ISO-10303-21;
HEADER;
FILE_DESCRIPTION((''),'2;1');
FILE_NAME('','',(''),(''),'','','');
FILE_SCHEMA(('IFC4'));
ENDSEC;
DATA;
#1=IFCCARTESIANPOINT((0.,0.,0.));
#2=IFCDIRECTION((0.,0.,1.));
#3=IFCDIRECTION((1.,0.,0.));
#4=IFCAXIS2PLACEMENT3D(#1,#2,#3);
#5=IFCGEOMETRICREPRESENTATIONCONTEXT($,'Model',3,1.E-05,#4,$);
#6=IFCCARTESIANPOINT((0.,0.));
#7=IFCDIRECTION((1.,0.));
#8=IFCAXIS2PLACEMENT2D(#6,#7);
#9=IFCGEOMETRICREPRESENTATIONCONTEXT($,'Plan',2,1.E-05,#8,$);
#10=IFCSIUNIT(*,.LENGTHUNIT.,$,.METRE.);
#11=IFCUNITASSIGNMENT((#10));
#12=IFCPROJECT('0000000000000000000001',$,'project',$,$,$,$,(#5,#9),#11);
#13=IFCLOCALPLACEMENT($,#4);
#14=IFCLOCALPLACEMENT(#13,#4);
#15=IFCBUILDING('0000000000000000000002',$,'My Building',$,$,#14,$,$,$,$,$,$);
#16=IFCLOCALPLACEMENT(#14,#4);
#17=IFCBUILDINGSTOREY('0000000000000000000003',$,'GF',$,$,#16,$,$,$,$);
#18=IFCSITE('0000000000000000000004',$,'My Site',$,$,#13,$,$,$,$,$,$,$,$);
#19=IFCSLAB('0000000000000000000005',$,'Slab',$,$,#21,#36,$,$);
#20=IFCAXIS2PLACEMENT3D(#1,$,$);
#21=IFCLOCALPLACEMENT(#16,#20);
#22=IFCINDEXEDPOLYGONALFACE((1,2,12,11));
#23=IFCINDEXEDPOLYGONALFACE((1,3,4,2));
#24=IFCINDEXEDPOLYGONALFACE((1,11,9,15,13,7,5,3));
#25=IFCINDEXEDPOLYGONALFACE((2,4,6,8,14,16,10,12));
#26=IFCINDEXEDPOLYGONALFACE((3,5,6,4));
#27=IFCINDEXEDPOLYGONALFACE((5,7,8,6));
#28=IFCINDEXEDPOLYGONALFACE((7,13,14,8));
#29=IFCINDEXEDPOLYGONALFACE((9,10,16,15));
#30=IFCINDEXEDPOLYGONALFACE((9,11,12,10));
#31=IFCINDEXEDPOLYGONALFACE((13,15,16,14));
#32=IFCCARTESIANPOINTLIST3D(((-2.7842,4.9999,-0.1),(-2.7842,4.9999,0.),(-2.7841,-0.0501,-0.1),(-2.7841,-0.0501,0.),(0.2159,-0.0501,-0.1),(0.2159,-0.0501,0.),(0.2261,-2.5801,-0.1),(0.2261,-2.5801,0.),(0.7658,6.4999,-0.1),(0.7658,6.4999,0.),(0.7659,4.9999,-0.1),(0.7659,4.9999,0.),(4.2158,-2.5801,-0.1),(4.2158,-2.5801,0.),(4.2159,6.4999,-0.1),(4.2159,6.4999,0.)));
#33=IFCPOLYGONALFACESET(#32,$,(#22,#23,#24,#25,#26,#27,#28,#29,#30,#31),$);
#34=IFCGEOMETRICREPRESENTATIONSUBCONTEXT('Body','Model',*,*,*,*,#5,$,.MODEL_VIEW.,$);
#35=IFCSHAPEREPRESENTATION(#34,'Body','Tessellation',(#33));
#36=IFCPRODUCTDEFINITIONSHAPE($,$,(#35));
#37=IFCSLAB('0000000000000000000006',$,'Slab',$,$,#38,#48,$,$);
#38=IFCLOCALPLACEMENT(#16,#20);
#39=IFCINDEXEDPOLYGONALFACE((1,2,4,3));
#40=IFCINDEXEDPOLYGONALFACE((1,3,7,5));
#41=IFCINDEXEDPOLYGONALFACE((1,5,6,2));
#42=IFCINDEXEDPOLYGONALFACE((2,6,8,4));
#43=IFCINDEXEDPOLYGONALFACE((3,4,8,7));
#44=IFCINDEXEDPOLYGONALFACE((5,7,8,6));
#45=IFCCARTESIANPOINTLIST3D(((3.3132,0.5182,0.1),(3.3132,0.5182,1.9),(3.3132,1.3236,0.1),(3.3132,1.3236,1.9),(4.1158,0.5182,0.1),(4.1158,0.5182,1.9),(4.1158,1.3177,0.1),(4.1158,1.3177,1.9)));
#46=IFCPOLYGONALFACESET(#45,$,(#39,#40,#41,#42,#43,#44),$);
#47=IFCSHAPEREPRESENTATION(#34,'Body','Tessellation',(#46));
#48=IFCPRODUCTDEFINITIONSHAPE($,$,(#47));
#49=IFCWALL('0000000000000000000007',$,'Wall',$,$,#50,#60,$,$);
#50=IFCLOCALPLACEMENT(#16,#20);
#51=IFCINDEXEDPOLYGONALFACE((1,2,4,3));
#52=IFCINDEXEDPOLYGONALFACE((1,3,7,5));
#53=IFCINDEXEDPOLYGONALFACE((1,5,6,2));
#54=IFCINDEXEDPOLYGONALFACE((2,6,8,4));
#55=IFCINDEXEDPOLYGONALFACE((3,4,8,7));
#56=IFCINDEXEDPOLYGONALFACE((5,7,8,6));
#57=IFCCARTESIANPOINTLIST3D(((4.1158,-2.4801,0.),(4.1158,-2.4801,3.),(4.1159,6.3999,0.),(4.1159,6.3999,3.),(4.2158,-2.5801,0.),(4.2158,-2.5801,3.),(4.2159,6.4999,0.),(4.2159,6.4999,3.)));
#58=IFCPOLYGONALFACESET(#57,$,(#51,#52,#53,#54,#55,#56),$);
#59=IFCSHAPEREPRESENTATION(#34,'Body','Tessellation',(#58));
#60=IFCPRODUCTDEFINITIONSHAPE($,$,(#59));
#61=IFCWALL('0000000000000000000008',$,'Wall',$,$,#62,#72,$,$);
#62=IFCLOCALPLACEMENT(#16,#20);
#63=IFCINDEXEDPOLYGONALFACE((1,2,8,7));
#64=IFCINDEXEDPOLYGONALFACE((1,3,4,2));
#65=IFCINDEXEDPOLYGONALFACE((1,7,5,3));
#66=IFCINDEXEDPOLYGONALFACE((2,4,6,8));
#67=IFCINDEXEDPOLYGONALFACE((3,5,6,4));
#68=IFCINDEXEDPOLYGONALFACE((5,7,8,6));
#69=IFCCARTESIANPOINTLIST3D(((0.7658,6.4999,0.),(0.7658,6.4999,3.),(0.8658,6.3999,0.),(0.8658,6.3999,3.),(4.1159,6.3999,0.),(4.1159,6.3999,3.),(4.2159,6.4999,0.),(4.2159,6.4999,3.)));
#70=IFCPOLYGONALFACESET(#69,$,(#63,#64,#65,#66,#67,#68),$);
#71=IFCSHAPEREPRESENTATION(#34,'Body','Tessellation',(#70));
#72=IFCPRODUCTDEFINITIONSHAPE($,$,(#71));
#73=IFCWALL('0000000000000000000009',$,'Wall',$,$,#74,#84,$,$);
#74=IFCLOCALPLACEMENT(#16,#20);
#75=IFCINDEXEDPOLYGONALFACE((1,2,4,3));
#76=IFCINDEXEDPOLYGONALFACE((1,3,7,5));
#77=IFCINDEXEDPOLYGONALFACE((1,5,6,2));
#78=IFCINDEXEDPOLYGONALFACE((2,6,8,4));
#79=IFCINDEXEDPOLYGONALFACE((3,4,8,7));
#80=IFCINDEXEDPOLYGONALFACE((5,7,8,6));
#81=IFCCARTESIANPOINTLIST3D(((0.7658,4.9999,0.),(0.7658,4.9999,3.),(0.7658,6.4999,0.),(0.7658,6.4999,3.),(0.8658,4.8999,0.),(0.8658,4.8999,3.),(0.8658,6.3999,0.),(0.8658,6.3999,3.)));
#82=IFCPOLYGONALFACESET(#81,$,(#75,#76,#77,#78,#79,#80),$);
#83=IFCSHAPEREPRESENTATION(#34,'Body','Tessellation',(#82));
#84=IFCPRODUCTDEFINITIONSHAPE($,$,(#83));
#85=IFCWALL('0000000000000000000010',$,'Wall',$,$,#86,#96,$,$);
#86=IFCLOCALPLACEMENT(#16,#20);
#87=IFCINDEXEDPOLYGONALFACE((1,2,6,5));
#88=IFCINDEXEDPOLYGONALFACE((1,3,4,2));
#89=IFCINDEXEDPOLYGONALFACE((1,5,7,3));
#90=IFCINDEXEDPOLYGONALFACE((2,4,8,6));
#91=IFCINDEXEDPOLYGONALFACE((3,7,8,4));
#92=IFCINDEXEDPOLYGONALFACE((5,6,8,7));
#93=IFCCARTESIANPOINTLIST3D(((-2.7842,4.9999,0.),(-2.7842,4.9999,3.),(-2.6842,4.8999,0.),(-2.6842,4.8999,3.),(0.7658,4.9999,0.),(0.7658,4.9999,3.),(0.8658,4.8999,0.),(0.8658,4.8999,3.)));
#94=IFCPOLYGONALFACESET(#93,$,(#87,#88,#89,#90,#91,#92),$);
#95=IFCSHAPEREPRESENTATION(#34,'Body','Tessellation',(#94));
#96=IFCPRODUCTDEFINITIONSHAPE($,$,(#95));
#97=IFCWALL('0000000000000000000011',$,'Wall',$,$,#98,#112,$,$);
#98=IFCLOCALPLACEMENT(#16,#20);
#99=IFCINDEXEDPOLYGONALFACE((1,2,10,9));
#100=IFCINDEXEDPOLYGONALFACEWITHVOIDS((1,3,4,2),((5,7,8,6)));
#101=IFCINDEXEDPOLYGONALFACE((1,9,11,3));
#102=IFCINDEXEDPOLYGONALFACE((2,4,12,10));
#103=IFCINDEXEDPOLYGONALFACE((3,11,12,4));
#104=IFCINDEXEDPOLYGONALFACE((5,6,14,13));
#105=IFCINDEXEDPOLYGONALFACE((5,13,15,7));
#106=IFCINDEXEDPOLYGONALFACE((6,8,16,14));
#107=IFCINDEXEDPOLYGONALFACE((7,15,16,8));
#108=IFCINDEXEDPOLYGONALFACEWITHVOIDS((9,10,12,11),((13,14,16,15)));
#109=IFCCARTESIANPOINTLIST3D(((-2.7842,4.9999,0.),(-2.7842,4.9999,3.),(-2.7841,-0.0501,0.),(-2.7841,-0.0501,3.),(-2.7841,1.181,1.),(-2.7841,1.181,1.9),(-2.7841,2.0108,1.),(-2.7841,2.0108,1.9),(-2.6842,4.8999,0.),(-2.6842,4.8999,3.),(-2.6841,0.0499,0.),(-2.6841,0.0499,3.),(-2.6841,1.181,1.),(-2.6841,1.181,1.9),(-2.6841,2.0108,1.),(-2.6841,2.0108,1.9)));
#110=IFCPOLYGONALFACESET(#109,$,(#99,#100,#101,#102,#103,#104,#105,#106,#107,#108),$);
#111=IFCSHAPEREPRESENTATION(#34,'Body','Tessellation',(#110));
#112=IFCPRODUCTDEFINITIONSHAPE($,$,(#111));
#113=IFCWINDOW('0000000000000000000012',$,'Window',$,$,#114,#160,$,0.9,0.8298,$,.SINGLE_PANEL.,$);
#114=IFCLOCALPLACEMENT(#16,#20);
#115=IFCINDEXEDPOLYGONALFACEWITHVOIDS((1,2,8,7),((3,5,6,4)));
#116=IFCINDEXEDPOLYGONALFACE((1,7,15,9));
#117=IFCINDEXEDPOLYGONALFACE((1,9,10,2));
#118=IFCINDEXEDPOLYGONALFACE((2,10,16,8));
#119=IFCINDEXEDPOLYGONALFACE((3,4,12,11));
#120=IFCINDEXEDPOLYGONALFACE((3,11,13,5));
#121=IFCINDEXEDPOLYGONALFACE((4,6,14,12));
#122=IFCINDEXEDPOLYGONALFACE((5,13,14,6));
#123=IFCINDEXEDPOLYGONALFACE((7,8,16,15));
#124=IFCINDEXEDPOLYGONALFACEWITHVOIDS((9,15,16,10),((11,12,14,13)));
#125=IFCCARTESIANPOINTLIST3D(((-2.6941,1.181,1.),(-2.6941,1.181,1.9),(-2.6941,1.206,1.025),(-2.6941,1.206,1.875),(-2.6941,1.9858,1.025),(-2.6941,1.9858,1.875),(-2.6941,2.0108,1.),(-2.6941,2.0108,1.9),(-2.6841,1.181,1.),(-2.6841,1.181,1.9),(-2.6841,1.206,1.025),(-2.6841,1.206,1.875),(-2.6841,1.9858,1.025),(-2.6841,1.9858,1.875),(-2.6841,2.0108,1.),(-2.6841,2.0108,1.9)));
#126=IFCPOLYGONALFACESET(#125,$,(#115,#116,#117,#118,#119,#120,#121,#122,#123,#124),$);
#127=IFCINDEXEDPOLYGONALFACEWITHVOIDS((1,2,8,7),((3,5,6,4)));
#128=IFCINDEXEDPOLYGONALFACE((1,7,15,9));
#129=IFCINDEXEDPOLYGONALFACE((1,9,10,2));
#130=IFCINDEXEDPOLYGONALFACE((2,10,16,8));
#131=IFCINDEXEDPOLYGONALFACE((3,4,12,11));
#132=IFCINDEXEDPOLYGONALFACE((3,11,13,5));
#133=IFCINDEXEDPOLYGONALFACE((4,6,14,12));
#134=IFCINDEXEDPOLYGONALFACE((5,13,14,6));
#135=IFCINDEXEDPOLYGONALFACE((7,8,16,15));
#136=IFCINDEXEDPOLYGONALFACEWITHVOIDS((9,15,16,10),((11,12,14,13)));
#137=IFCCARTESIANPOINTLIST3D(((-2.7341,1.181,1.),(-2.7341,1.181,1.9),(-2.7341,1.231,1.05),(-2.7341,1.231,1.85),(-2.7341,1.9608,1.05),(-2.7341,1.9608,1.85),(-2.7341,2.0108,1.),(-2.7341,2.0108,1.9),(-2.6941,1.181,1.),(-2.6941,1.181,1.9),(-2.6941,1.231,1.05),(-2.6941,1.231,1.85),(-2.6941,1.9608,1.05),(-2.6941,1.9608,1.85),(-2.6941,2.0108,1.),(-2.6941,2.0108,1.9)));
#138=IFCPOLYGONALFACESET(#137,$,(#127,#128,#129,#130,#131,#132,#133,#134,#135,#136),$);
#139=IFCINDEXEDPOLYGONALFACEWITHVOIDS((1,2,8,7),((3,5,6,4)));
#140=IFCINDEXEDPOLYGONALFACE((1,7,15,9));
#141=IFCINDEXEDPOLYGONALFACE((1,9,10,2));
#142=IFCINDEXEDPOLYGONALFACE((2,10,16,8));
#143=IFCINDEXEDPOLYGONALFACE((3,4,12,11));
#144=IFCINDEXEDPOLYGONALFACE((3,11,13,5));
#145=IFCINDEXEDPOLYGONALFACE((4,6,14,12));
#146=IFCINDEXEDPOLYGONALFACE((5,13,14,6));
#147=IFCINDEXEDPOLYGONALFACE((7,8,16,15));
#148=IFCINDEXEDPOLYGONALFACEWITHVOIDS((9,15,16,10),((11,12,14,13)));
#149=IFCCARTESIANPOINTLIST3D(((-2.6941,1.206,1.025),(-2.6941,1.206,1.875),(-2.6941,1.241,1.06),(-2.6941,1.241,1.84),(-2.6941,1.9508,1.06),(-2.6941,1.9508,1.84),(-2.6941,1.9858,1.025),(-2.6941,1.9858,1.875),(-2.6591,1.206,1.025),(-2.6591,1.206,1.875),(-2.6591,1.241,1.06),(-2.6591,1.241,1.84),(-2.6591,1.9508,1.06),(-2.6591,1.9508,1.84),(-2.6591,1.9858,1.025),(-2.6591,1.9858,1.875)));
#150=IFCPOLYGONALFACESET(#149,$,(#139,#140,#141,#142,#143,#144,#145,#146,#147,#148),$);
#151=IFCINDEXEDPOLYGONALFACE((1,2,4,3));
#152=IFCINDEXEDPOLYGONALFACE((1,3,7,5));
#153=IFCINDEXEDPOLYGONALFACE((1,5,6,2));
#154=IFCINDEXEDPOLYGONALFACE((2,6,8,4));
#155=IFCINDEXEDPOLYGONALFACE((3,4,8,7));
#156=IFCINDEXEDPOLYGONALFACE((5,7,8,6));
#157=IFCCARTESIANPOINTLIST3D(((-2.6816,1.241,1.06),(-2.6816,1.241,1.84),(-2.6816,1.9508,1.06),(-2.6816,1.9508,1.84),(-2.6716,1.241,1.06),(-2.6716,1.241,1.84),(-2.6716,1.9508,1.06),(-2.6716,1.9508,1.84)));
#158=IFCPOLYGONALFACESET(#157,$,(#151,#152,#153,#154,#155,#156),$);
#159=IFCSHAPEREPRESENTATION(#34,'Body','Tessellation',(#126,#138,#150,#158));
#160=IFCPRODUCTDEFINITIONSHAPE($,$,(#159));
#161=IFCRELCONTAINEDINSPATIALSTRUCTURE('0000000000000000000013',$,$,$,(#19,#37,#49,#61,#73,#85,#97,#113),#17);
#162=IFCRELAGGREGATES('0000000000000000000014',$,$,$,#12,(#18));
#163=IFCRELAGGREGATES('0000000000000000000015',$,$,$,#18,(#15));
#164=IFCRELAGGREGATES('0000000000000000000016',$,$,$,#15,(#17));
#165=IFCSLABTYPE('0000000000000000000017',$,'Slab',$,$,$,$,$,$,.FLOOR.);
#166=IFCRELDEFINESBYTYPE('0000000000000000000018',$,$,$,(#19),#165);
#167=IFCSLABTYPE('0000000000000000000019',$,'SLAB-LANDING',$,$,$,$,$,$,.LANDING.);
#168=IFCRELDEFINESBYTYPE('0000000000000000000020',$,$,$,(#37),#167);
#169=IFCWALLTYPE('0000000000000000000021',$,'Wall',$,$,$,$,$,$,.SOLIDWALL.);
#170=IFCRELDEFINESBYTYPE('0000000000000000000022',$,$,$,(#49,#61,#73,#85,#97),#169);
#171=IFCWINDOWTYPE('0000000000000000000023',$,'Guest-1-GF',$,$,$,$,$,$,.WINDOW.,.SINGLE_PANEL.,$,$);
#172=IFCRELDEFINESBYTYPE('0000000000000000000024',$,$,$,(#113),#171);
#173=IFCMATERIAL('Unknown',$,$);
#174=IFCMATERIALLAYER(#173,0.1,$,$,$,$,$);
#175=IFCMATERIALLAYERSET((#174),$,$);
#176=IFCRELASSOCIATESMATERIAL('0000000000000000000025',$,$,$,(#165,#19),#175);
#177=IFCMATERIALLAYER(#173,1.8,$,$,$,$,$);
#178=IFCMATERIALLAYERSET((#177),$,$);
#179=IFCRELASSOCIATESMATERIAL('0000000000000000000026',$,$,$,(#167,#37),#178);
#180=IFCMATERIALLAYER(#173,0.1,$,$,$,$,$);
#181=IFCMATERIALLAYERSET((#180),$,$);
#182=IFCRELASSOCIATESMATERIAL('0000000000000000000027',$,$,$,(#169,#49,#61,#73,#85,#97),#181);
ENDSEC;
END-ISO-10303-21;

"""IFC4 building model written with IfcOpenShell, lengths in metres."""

from ifc_helpers import new_model, entity, si_unit, frame, origin_with_axes, origin_2d_with_axis, place, context, subcontext, project, spatial, line, indexed_curve, outline, extrude, shape, source, transform, mapped, material, layer, layer_set, layer_usage, type_object, type_shapes, element, fill, save


model = new_model("IFC4")

# Units and contexts
model_context = context("Model", 3, precision=1e-05, world=origin_with_axes())
plan_context = context("Plan", 2, precision=1e-05, world=origin_2d_with_axis())
body_context_1 = subcontext(model_context, "Body", "Model", "MODEL_VIEW")
body_context_2 = subcontext(plan_context, "Body", "Plan", "PLAN_VIEW")
ifc_project = project(units=[si_unit("LENGTHUNIT", "METRE")], contexts=[model_context, plan_context])

# Site, building, storey
site_placement = place(None, origin_with_axes())
site = spatial("IfcSite", under=ifc_project, at=site_placement, Name="My Site")
building_placement = place(site_placement, origin_with_axes())
building = spatial("IfcBuilding", under=site, at=building_placement, Name="My Building")
storey_placement = place(building_placement, origin_with_axes())
storey = spatial("IfcBuildingStorey", under=building, at=storey_placement, Name="GF")

# Slabs
ifc_material_1 = material(Name="Unknown")
ifc_layer_1 = layer(ifc_material_1, 0.1)
ifc_layer_set_1 = layer_set([ifc_layer_1])
ifc_layer_usage_1 = layer_usage(ifc_layer_set_1, "AXIS3", "POSITIVE", -0.1)
slab_type_1 = type_object("IfcSlabType", Name="Slab", PredefinedType="FLOOR", material=ifc_layer_set_1)
slab_1_placement = place(storey_placement, frame((0.2261, -2.5801, 0.0), z_axis=(0.0, 0.0, 1.0), x_axis=(1.0, 0.0, 0.0)))
element("IfcSlab", 1, at=slab_1_placement, inside=storey, type_object=slab_type_1, material=ifc_layer_usage_1, Name="Slab", context=body_context_1, shape_type="SweptSolid", body=[
    extrude(outline(indexed_curve([(0.0, 0.0), (3.9897, 0.0), (3.9897, 9.08), (0.5397, 9.08), (0.5397, 7.58), (-3.0103, 7.58), (-3.0103, 2.53), (-0.0103, 2.53), (0.0, 0.0)])), frame((0.0, 0.0, -0.1), z_axis=(0.0, 0.0, 1.0), x_axis=(1.0, 0.0, 0.0)), (0.0, 0.0, 1.0), 0.1),
])
ifc_layer_2 = layer(ifc_material_1, 1.8)
ifc_layer_set_2 = layer_set([ifc_layer_2])
ifc_layer_usage_2 = layer_usage(ifc_layer_set_2, "AXIS3", "POSITIVE", -0.1)
slab_type_2 = type_object("IfcSlabType", Name="SLAB-LANDING", PredefinedType="LANDING", material=ifc_layer_set_2)
slab_2_placement = place(storey_placement, frame((3.3132, 1.3236, 0.2), z_axis=(0.0, 0.0, 1.0), x_axis=(1.0, 0.0, 0.0)))
element("IfcSlab", 2, at=slab_2_placement, inside=storey, type_object=slab_type_2, material=ifc_layer_usage_2, Name="Slab", context=body_context_1, shape_type="SweptSolid", body=[
    extrude(outline(indexed_curve([(0.0, 0.0), (0.0, -0.8055), (0.8026, -0.8055), (0.8026, -0.006), (0.0, 0.0)])), frame((0.0, 0.0, -0.1), z_axis=(0.0, 0.0, 1.0), x_axis=(1.0, 0.0, 0.0)), (0.0, 0.0, 1.0), 1.8),
])

# Shared definitions
ifc_layer_3 = layer(ifc_material_1, 0.1)
ifc_layer_set_3 = layer_set([ifc_layer_3])
wall_type = type_object("IfcWallType", Name="Wall", PredefinedType="SOLIDWALL", material=ifc_layer_set_3)

# Walls
ifc_layer_usage_3 = layer_usage(ifc_layer_set_3, "AXIS2", "POSITIVE", 0.0)
wall_1_placement = place(storey_placement, frame((4.2158, -2.5801, 0.0), z_axis=(0.0, 0.0, 1.0), x_axis=(0.0, 1.0, 0.0)))
element("IfcWall", 3, at=wall_1_placement, inside=storey, type_object=wall_type, material=ifc_layer_usage_3, Name="Wall", context=body_context_1, shape_type="SweptSolid", body=[
    extrude(outline(indexed_curve([(0.0, 0.0), (0.1, 0.1), (8.98, 0.1), (9.08, 0.0)], segments=[line(1, 2, 3, 4, 1)])), origin_with_axes(), (0.0, 0.0, 1.0), 3.0),
])
ifc_layer_usage_4 = layer_usage(ifc_layer_set_3, "AXIS2", "POSITIVE", 0.0)
wall_2_placement = place(storey_placement, frame((4.2159, 6.4999, 0.0), z_axis=(0.0, 0.0, 1.0), x_axis=(-1.0, 0.0, 0.0)))
element("IfcWall", 4, at=wall_2_placement, inside=storey, type_object=wall_type, material=ifc_layer_usage_4, Name="Wall", context=body_context_1, shape_type="SweptSolid", body=[
    extrude(outline(indexed_curve([(0.0, 0.0), (0.1, 0.1), (3.35, 0.1), (3.45, 0.0)], segments=[line(1, 2, 3, 4, 1)])), origin_with_axes(), (0.0, 0.0, 1.0), 3.0),
])
ifc_layer_usage_5 = layer_usage(ifc_layer_set_3, "AXIS2", "POSITIVE", 0.0)
wall_3_placement = place(storey_placement, frame((0.7658, 6.4999, 0.0), z_axis=(0.0, 0.0, 1.0), x_axis=(0.0, -1.0, 0.0)))
element("IfcWall", 5, at=wall_3_placement, inside=storey, type_object=wall_type, material=ifc_layer_usage_5, Name="Wall", context=body_context_1, shape_type="SweptSolid", body=[
    extrude(outline(indexed_curve([(0.0, 0.0), (0.1, 0.1), (1.6, 0.1), (1.5, 0.0)], segments=[line(1, 2, 3, 4, 1)])), origin_with_axes(), (0.0, 0.0, 1.0), 3.0),
])
ifc_layer_usage_6 = layer_usage(ifc_layer_set_3, "AXIS2", "POSITIVE", 0.0)
wall_4_placement = place(storey_placement, frame((0.7658, 4.9999, 0.0), z_axis=(0.0, 0.0, 1.0), x_axis=(-1.0, 0.0, 0.0)))
element("IfcWall", 6, at=wall_4_placement, inside=storey, type_object=wall_type, material=ifc_layer_usage_6, Name="Wall", context=body_context_1, shape_type="SweptSolid", body=[
    extrude(outline(indexed_curve([(0.0, 0.0), (-0.1, 0.1), (3.45, 0.1), (3.55, 0.0)], segments=[line(1, 2, 3, 4, 1)])), origin_with_axes(), (0.0, 0.0, 1.0), 3.0),
])

# Wall, opening, window
ifc_layer_usage_7 = layer_usage(ifc_layer_set_3, "AXIS2", "POSITIVE", 0.0)
wall_5_placement = place(storey_placement, frame((-2.7842, 4.9999, 0.0), z_axis=(0.0, 0.0, 1.0), x_axis=(0.0, -1.0, 0.0)))
wall_5 = element("IfcWall", 7, at=wall_5_placement, inside=storey, type_object=wall_type, material=ifc_layer_usage_7, Name="Wall", context=body_context_1, shape_type="SweptSolid", body=[
    extrude(outline(indexed_curve([(0.0, 0.0), (0.1, 0.1), (4.95, 0.1), (5.05, 0.0)], segments=[line(1, 2, 3, 4, 1)])), origin_with_axes(), (0.0, 0.0, 1.0), 3.0),
])
shared_shape_1 = source(origin_with_axes(), body_context_1, "Body", "SweptSolid", [
    extrude(outline(indexed_curve([(0.0, 0.0), (0.8298, 0.0), (0.8298, 0.9), (0.0, 0.9)], segments=[line(1, 2, 3, 4, 1)])), frame((0.0, -0.6, 0.0), z_axis=(0.0, -1.0, 0.0), x_axis=(1.0, 0.0, 0.0)), (0.0, 0.0, -1.0), 1.2),
])
opening_1_placement = place(wall_5_placement, frame((2.989, 0.0, 1.0), z_axis=(0.0, 0.0, 1.0), x_axis=(1.0, 0.0, 0.0)))
opening_1 = element("IfcOpeningElement", 8, at=opening_1_placement, cuts=wall_5, PredefinedType="OPENING", context=body_context_1, shape_type="MappedRepresentation", body=[
    mapped(shared_shape_1, transform((0.0, 0.0, 0.0), x_axis=(1.0, 0.0, 0.0), y_axis=(0.0, 1.0, 0.0), z_axis=(0.0, 0.0, 1.0), scale=1.0)),
])
window_type_1 = type_object("IfcWindowType", Name="Guest-1-GF", PartitioningType="SINGLE_PANEL", PredefinedType="WINDOW")
shared_shape_2 = source(origin_with_axes(), body_context_1, "Body", "SweptSolid", [
    extrude(outline(indexed_curve([(0.0, 0.0), (0.8298, 0.0), (0.8298, 0.9), (0.0, 0.9)], segments=[line(1, 2, 3, 4, 1)]), holes=[indexed_curve([(0.025, 0.025), (0.8048, 0.025), (0.8048, 0.875), (0.025, 0.875)], segments=[line(1, 2, 3, 4, 1)])]), frame((0.0, 0.09, 0.0), z_axis=(0.0, -1.0, 0.0), x_axis=(1.0, 0.0, 0.0)), (0.0, 0.0, -1.0), 0.01),
    extrude(outline(indexed_curve([(0.0, 0.0), (0.8298, 0.0), (0.8298, 0.9), (0.0, 0.9)], segments=[line(1, 2, 3, 4, 1)]), holes=[indexed_curve([(0.05, 0.05), (0.7798, 0.05), (0.7798, 0.85), (0.05, 0.85)], segments=[line(1, 2, 3, 4, 1)])]), frame((0.0, 0.05, 0.0), z_axis=(0.0, -1.0, 0.0), x_axis=(1.0, 0.0, 0.0)), (0.0, 0.0, -1.0), 0.04),
    extrude(outline(indexed_curve([(0.0, 0.0), (0.7798, 0.0), (0.7798, 0.85), (0.0, 0.85)], segments=[line(1, 2, 3, 4, 1)]), holes=[indexed_curve([(0.035, 0.035), (0.7448, 0.035), (0.7448, 0.815), (0.035, 0.815)], segments=[line(1, 2, 3, 4, 1)])]), frame((0.025, 0.09, 0.025), z_axis=(0.0, -1.0, 0.0), x_axis=(1.0, 0.0, 0.0)), (0.0, 0.0, -1.0), 0.035),
    extrude(outline(indexed_curve([(0.035, 0.035), (0.7448, 0.035), (0.7448, 0.815), (0.035, 0.815)], segments=[line(1, 2, 3, 4, 1)])), frame((0.025, 0.1025, 0.025), z_axis=(0.0, -1.0, 0.0), x_axis=(1.0, 0.0, 0.0)), (0.0, 0.0, -1.0), 0.01),
])
shared_shape_3 = source(origin_with_axes(), body_context_2, "Body", "Curve2D", [
    entity("IfcIndexedPolyCurve", entity("IfcCartesianPointList2D", [[0.05, 0.05], [0.7798, 0.05]])),
    entity("IfcIndexedPolyCurve", entity("IfcCartesianPointList2D", [[0.0, 0.1], [0.025, 0.1], [0.025, 0.09], [0.05, 0.09], [0.05, 0.05], [0.0, 0.05]]), [entity("IfcLineIndex", [1, 2, 3, 4, 5, 6, 1])]),
    entity("IfcIndexedPolyCurve", entity("IfcCartesianPointList2D", [[0.8298, 0.1], [0.8048, 0.1], [0.8048, 0.09], [0.7798, 0.09], [0.7798, 0.05], [0.8298, 0.05]]), [entity("IfcLineIndex", [1, 2, 3, 4, 5, 6, 1])]),
    entity("IfcIndexedPolyCurve", entity("IfcCartesianPointList2D", [[0.025, 0.09], [0.06, 0.09], [0.06, 0.125], [0.025, 0.125]]), [entity("IfcLineIndex", [1, 2, 3, 4, 1])]),
    entity("IfcIndexedPolyCurve", entity("IfcCartesianPointList2D", [[0.8048, 0.09], [0.7698, 0.09], [0.7698, 0.125], [0.8048, 0.125]]), [entity("IfcLineIndex", [1, 2, 3, 4, 1])]),
    entity("IfcIndexedPolyCurve", entity("IfcCartesianPointList2D", [[0.06, 0.09], [0.7698, 0.09]])),
    entity("IfcIndexedPolyCurve", entity("IfcCartesianPointList2D", [[0.06, 0.125], [0.7698, 0.125]])),
    entity("IfcIndexedPolyCurve", entity("IfcCartesianPointList2D", [[0.06, 0.1075], [0.7698, 0.1075]])),
])
type_shapes(window_type_1, [shared_shape_2, shared_shape_3])
window_1_placement = place(opening_1_placement, frame((0.0, 0.0, 0.0), z_axis=(0.0, 0.0, 1.0), x_axis=(1.0, 0.0, 0.0)))
window_1 = element("IfcWindow", 9, at=window_1_placement, inside=storey, type_object=window_type_1, Name="Window", OverallHeight=0.9, OverallWidth=0.8298, PartitioningType="SINGLE_PANEL", shapes=[
    shape(body_context_1, "Body", "MappedRepresentation", [mapped(shared_shape_2, transform((0.0, 0.0, 0.0), x_axis=(1.0, 0.0, 0.0), y_axis=(0.0, 1.0, 0.0), z_axis=(0.0, 0.0, 1.0), scale=1.0))]),
    shape(body_context_2, "Body", "MappedRepresentation", [mapped(shared_shape_3, transform((0.0, 0.0, 0.0), x_axis=(1.0, 0.0, 0.0), y_axis=(0.0, 1.0, 0.0), z_axis=(0.0, 0.0, 1.0), scale=1.0))]),
])
fill(opening_1, window_1)

save(model, "model.ifc")
